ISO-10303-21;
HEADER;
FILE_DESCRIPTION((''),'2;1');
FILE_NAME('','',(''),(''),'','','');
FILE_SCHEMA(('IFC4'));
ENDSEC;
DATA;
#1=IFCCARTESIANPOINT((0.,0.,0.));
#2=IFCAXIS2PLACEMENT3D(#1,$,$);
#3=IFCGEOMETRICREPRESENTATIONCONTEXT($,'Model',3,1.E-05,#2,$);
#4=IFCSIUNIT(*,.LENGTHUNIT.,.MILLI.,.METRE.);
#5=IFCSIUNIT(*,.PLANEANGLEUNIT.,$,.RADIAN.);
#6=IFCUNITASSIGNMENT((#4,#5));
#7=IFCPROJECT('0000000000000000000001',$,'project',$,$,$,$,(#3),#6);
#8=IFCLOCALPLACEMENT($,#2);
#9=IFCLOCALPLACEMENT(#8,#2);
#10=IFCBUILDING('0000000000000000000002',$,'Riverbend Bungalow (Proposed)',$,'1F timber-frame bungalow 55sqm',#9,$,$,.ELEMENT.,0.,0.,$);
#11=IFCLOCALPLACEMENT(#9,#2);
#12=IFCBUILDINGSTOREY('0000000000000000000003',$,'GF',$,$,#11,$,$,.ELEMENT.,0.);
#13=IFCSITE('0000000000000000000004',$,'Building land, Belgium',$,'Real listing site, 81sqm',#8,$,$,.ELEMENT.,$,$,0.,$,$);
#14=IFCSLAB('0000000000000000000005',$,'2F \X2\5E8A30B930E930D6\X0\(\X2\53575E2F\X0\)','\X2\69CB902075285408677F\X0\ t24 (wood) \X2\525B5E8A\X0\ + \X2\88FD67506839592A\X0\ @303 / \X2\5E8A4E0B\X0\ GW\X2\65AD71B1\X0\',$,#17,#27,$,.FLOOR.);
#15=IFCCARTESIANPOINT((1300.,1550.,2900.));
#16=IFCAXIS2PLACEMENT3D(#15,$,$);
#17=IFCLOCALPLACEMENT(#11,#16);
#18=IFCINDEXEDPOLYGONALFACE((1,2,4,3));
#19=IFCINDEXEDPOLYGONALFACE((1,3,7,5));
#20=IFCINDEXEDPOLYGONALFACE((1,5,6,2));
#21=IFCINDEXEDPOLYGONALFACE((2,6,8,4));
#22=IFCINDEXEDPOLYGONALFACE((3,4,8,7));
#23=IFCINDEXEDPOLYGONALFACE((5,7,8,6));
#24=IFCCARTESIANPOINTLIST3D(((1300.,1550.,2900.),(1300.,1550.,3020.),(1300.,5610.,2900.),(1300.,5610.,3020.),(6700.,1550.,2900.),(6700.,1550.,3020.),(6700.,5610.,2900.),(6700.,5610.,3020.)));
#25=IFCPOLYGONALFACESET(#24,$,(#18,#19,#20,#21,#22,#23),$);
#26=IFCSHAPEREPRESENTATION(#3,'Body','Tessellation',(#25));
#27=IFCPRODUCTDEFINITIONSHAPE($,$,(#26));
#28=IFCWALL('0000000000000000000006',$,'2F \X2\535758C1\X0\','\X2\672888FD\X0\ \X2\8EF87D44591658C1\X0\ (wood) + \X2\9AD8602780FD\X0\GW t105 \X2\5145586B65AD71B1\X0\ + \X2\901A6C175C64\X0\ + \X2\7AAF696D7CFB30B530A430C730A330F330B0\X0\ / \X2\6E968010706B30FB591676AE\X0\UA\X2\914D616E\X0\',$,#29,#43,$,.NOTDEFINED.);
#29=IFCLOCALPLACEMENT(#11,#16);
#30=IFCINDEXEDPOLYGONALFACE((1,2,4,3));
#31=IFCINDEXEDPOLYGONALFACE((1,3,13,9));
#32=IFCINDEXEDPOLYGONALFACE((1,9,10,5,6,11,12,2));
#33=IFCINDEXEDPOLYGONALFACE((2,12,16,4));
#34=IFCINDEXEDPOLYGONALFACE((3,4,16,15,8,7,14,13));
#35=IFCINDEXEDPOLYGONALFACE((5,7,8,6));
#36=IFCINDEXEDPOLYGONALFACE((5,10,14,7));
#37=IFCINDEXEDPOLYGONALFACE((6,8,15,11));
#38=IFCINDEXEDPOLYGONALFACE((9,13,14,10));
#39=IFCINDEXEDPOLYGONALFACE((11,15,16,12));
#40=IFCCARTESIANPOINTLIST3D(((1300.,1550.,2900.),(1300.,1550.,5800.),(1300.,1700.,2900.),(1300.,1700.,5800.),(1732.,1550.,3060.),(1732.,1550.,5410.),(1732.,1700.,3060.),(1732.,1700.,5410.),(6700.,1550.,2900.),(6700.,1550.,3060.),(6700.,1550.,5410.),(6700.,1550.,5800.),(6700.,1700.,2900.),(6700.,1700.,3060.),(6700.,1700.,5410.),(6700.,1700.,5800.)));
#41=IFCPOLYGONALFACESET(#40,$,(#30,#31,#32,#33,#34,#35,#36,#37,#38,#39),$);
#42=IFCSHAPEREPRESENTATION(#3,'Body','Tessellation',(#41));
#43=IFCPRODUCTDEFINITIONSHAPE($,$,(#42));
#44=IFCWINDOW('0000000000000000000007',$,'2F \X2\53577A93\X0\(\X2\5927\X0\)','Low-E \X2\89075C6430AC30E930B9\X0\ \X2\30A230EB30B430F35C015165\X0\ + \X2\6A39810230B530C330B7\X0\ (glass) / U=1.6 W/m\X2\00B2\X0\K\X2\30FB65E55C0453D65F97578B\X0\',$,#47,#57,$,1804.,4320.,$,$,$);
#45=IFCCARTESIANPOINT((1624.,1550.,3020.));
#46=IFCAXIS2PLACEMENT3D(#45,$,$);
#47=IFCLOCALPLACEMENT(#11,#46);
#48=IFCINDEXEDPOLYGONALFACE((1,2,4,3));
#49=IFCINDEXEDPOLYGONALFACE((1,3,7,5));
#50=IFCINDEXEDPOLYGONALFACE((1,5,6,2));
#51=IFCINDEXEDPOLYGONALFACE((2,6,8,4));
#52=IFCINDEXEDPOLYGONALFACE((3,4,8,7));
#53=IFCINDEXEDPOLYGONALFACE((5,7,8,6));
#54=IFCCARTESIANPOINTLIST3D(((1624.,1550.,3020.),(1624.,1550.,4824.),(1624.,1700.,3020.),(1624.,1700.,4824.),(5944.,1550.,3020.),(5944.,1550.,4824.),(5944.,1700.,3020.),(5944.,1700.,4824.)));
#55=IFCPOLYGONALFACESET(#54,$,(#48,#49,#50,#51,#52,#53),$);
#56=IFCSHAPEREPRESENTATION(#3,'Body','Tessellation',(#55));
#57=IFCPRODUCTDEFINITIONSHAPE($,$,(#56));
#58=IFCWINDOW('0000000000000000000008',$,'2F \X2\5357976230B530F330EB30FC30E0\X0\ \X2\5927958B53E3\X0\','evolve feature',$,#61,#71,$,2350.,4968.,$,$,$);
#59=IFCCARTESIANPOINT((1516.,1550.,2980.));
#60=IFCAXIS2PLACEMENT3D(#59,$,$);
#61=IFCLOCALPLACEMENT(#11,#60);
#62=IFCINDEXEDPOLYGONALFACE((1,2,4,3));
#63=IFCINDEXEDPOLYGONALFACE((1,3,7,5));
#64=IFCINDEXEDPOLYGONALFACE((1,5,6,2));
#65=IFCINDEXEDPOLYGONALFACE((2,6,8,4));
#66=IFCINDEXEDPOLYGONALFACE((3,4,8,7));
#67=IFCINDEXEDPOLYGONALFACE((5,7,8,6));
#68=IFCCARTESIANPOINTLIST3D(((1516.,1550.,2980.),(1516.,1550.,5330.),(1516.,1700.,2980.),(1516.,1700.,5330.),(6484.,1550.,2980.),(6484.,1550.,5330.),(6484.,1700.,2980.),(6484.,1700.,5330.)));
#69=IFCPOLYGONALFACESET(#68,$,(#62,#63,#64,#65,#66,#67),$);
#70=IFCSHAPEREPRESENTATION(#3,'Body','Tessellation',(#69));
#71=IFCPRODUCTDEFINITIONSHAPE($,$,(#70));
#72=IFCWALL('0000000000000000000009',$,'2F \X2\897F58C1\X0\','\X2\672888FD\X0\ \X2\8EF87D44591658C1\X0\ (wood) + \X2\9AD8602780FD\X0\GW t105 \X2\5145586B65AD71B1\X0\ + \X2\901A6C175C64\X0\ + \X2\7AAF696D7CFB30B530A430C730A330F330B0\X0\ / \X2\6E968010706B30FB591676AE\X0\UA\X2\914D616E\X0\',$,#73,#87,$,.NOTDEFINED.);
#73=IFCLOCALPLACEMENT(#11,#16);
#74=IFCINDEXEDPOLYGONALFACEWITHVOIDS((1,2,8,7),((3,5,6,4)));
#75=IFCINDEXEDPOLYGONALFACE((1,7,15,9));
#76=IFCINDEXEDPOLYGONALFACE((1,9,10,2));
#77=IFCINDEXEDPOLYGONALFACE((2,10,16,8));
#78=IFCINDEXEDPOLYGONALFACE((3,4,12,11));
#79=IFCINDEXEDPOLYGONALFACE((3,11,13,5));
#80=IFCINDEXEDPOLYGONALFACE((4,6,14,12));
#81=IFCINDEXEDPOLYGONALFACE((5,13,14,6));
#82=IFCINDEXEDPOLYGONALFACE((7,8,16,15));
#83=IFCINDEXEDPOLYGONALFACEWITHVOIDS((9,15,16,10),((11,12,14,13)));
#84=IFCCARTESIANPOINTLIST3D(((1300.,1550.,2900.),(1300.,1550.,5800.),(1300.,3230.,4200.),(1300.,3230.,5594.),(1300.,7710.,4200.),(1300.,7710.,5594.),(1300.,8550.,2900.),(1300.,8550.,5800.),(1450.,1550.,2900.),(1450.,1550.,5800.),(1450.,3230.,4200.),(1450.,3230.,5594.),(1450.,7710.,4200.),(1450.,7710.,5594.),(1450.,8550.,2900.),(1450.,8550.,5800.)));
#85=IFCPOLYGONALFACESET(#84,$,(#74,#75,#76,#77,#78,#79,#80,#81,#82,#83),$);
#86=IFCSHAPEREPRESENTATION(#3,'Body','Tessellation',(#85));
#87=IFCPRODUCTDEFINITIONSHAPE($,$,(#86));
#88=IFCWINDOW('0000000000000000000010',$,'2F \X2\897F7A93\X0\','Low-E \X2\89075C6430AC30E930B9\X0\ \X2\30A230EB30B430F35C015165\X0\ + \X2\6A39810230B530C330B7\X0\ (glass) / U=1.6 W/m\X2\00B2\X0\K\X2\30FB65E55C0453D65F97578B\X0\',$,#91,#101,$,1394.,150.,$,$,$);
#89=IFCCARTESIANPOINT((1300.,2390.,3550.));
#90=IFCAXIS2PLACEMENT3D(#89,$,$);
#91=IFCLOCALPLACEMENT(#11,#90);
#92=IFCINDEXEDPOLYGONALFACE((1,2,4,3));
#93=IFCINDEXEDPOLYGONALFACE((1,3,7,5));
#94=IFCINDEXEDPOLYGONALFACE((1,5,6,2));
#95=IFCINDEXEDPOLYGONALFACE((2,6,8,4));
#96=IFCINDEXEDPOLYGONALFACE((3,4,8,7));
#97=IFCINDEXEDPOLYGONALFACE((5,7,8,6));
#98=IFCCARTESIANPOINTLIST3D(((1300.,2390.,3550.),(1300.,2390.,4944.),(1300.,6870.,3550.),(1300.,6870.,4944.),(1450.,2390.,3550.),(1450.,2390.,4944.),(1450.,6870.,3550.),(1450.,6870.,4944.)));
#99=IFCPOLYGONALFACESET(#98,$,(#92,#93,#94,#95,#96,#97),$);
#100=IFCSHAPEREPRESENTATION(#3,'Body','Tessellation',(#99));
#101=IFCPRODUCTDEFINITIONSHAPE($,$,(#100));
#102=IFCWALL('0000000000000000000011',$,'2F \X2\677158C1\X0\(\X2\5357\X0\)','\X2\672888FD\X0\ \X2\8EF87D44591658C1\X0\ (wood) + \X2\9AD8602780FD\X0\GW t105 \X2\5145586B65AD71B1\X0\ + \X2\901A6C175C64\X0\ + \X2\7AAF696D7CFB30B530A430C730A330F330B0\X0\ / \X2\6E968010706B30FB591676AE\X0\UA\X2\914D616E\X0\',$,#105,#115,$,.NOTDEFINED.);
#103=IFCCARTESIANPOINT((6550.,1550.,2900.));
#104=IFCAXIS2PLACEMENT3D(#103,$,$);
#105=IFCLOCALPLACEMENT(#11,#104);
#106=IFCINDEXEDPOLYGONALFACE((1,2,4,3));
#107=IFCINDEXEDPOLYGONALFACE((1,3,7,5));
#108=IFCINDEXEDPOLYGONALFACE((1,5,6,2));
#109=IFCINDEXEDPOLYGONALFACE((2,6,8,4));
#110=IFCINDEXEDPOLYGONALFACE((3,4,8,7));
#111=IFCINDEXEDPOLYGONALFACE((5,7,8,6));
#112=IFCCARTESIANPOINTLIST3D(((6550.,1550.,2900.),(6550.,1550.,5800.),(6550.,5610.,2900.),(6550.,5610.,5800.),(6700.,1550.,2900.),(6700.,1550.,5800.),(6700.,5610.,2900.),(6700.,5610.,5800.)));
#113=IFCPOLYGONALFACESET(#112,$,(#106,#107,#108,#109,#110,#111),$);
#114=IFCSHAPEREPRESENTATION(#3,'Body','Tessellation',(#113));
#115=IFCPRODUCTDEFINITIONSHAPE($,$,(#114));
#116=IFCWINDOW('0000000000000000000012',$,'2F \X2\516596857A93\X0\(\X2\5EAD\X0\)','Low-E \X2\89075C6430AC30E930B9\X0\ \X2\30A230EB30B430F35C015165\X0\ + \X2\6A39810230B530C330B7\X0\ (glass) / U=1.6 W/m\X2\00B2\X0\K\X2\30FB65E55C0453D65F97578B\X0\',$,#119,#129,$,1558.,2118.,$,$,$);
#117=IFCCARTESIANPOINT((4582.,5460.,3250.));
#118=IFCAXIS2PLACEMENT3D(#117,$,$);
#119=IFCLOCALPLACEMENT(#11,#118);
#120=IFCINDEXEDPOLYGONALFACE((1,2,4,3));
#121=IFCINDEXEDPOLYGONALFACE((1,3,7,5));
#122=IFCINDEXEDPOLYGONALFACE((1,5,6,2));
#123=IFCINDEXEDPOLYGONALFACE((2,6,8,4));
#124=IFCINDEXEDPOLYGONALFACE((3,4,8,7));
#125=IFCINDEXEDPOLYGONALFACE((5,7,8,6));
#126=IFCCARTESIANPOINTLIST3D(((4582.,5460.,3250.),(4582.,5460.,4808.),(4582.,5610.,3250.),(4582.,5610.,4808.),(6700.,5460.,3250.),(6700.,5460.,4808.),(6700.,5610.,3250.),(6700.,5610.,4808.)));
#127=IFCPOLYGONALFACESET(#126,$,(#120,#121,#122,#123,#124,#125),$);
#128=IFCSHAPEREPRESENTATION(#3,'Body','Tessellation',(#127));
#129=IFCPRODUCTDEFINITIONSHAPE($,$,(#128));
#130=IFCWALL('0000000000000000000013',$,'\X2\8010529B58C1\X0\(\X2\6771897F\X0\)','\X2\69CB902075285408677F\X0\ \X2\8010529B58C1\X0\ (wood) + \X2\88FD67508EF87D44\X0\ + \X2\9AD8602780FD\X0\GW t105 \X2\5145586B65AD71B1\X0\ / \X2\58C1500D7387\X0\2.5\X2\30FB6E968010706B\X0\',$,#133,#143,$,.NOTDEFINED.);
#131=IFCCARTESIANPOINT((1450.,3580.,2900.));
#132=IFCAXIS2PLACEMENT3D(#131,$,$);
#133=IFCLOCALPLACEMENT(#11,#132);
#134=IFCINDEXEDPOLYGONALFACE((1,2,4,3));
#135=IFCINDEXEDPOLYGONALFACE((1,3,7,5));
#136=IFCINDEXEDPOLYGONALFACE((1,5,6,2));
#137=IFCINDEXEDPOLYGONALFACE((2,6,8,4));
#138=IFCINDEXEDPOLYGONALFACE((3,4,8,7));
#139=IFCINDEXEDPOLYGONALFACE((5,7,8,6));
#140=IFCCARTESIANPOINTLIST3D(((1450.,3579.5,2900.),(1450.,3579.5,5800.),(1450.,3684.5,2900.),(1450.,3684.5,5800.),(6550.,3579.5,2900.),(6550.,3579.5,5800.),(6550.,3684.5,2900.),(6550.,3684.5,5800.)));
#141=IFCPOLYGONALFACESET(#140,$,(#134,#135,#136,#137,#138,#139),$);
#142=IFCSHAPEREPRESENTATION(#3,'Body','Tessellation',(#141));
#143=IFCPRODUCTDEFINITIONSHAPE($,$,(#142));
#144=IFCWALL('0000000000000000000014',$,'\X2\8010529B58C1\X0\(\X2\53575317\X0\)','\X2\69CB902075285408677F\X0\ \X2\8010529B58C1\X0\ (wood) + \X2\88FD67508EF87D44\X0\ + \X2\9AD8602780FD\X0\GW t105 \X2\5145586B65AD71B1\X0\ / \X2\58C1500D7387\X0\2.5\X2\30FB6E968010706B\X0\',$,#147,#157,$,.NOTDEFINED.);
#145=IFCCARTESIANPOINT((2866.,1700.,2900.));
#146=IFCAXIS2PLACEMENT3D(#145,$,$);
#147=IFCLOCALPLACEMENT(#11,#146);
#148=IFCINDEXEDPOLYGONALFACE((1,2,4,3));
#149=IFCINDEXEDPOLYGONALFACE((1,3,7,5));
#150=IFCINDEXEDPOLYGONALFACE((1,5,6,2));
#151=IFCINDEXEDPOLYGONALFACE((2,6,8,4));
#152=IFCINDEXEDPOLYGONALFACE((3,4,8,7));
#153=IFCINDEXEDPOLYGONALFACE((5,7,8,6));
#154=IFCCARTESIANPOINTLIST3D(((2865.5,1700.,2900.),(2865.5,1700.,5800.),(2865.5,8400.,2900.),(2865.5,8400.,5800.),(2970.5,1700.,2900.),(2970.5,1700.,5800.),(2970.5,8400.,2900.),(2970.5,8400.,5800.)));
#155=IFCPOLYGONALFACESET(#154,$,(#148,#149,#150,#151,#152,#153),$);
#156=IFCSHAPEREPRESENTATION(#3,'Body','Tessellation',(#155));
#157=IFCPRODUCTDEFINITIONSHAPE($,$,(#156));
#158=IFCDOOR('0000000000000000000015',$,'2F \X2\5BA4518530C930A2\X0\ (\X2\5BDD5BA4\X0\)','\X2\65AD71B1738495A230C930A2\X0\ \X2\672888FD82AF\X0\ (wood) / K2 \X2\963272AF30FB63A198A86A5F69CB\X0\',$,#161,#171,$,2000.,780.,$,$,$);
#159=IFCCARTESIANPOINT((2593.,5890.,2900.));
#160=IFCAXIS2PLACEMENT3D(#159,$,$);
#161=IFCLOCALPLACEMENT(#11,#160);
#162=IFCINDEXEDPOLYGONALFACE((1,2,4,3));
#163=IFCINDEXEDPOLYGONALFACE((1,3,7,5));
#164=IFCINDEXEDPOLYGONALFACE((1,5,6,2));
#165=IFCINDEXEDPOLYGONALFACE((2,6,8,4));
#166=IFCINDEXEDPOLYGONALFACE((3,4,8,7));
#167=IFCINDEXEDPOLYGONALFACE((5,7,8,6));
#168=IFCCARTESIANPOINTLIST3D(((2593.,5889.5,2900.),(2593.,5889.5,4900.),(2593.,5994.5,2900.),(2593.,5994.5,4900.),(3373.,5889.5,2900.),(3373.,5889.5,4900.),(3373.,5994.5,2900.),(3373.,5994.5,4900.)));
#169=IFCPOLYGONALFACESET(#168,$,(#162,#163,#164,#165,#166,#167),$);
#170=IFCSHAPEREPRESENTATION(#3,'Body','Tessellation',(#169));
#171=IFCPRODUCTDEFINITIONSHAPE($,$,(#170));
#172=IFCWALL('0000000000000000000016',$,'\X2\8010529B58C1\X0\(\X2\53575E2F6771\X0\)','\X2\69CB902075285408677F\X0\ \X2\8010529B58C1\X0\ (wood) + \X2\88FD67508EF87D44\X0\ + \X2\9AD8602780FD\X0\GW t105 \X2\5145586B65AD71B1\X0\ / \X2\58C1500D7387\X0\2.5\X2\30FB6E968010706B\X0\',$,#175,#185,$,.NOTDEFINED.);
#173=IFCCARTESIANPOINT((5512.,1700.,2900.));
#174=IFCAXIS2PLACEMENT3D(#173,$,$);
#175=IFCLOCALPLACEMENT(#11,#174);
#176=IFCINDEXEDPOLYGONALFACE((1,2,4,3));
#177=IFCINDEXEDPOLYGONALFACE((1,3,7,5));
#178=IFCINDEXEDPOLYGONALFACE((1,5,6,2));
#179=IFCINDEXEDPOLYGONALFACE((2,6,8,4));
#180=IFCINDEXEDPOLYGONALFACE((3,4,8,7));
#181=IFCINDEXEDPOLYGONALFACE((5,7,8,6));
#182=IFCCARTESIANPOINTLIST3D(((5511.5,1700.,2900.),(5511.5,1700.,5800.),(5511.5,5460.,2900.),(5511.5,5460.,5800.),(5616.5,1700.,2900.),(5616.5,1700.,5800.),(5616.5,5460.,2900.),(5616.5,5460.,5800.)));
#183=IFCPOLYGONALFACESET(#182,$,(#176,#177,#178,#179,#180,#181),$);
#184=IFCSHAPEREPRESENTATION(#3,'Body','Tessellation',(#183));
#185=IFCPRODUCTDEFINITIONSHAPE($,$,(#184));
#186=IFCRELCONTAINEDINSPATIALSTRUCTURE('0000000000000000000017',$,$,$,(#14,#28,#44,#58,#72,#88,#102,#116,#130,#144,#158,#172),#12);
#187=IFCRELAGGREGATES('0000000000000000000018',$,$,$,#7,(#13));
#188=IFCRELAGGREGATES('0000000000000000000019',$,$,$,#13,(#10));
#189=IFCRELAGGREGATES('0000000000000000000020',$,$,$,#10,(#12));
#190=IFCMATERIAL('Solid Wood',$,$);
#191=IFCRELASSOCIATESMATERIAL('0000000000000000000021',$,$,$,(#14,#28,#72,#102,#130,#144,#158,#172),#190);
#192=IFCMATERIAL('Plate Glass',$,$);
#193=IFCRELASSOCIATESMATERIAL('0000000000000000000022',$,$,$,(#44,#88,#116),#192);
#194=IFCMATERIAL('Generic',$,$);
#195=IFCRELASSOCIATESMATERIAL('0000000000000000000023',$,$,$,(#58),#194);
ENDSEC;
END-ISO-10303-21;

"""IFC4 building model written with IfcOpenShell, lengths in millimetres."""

from ifc_helpers import new_model, si_unit, frame, frame_2d, origin, place, context, project, spatial, rectangle, extrude, material, element, fill, save


model = new_model("IFC4")

# Units and contexts
model_context = context("Model", 3, precision=1e-05, world=origin())
ifc_project = project(units=[si_unit("LENGTHUNIT", "METRE", prefix="MILLI"), si_unit("PLANEANGLEUNIT", "RADIAN")], contexts=[model_context])

# Site, building, storey
site_placement = place(None, origin())
site = spatial("IfcSite", under=ifc_project, at=site_placement, Name="Building land, Belgium", ObjectType="Real listing site, 81sqm", CompositionType="ELEMENT", RefElevation=0.0)
building_placement = place(site_placement, origin())
building = spatial("IfcBuilding", under=site, at=building_placement, Name="Riverbend Bungalow (Proposed)", ObjectType="1F timber-frame bungalow 55sqm", CompositionType="ELEMENT", ElevationOfRefHeight=0.0, ElevationOfTerrain=0.0)
storey_placement = place(building_placement, origin())
storey = spatial("IfcBuildingStorey", under=building, at=storey_placement, Name="GF", CompositionType="ELEMENT", Elevation=0.0)

# Slab
ifc_material_1 = material(Name="Solid Wood")
slab_placement = place(storey_placement, frame((1300.0, 1550.0, 2900.0)))
element("IfcSlab", 1, at=slab_placement, inside=storey, material=ifc_material_1, Name="2F 床スラブ(南帯)", Description="構造用合板 t24 (wood) 剛床 + 製材根太 @303 / 床下 GW断熱", PredefinedType="FLOOR", context=model_context, shape_type="SweptSolid", body=[
    extrude(rectangle(XDim=5400.0, YDim=4060.0, at=frame_2d((2700.0, 2030.0))), frame((1300.0, 1550.0, 2900.0)), (0.0, 0.0, 1.0), 120.0),
])

# Wall, openings, windows
wall_1_placement = place(storey_placement, frame((1300.0, 1550.0, 2900.0)))
wall_1 = element("IfcWall", 2, at=wall_1_placement, inside=storey, material=ifc_material_1, Name="2F 南壁", Description="木製 軸組外壁 (wood) + 高性能GW t105 充填断熱 + 通気層 + 窯業系サイディング / 準耐火・外皮UA配慮", PredefinedType="NOTDEFINED", context=model_context, shape_type="SweptSolid", body=[
    extrude(rectangle(XDim=5400.0, YDim=150.0, at=frame_2d((2700.0, 75.0))), frame((1300.0, 1550.0, 2900.0)), (0.0, 0.0, 1.0), 2900.0),
])
opening_1_placement = place(storey_placement, frame((1624.0, 1550.0, 3020.0)))
opening_1 = element("IfcOpeningElement", 3, at=opening_1_placement, cuts=wall_1, PredefinedType="NOTDEFINED", context=model_context, shape_type="SweptSolid", body=[
    extrude(rectangle(XDim=4320.0, YDim=150.0, at=frame_2d((2160.0, 75.0))), frame((1624.0, 1550.0, 3020.0)), (0.0, 0.0, 1.0), 1804.0),
])
opening_2_placement = place(storey_placement, frame((1516.0, 1550.0, 2980.0)))
opening_2 = element("IfcOpeningElement", 4, at=opening_2_placement, cuts=wall_1, PredefinedType="NOTDEFINED", context=model_context, shape_type="SweptSolid", body=[
    extrude(rectangle(XDim=4968.0, YDim=150.0, at=frame_2d((2484.0, 75.0))), frame((1516.0, 1550.0, 2980.0)), (0.0, 0.0, 1.0), 2350.0),
])
ifc_material_2 = material(Name="Plate Glass")
window_1_placement = place(storey_placement, frame((1624.0, 1550.0, 3020.0)))
window_1 = element("IfcWindow", 5, at=window_1_placement, inside=storey, material=ifc_material_2, Name="2F 南窓(大)", Description="Low-E 複層ガラス アルゴン封入 + 樹脂サッシ (glass) / U=1.6 W/m²K・日射取得型", OverallHeight=1804.0, OverallWidth=4320.0, context=model_context, shape_type="SweptSolid", body=[
    extrude(rectangle(XDim=4320.0, YDim=150.0, at=frame_2d((2160.0, 75.0))), frame((1624.0, 1550.0, 3020.0)), (0.0, 0.0, 1.0), 1804.0),
])
fill(opening_1, window_1)
ifc_material_3 = material(Name="Generic")
window_2_placement = place(storey_placement, frame((1516.0, 1550.0, 2980.0)))
window_2 = element("IfcWindow", 6, at=window_2_placement, inside=storey, material=ifc_material_3, Name="2F 南面サンルーム 大開口", Description="evolve feature", OverallHeight=2350.0, OverallWidth=4968.0, context=model_context, shape_type="SweptSolid", body=[
    extrude(rectangle(XDim=4968.0, YDim=150.0, at=frame_2d((2484.0, 75.0))), frame((1516.0, 1550.0, 2980.0)), (0.0, 0.0, 1.0), 2350.0),
])
fill(opening_2, window_2)

# Walls, openings, windows
wall_2_placement = place(storey_placement, frame((1300.0, 1550.0, 2900.0)))
wall_2 = element("IfcWall", 7, at=wall_2_placement, inside=storey, material=ifc_material_1, Name="2F 西壁", Description="木製 軸組外壁 (wood) + 高性能GW t105 充填断熱 + 通気層 + 窯業系サイディング / 準耐火・外皮UA配慮", PredefinedType="NOTDEFINED", context=model_context, shape_type="SweptSolid", body=[
    extrude(rectangle(XDim=150.0, YDim=7000.0, at=frame_2d((75.0, 3500.0))), frame((1300.0, 1550.0, 2900.0)), (0.0, 0.0, 1.0), 2900.0),
])
opening_3_placement = place(storey_placement, frame((1300.0, 2390.0, 3550.0)))
opening_3 = element("IfcOpeningElement", 8, at=opening_3_placement, cuts=wall_2, PredefinedType="NOTDEFINED", context=model_context, shape_type="SweptSolid", body=[
    extrude(rectangle(XDim=150.0, YDim=4480.0, at=frame_2d((75.0, 2240.0))), frame((1300.0, 2390.0, 3550.0)), (0.0, 0.0, 1.0), 1394.0),
])
window_3_placement = place(storey_placement, frame((1300.0, 2390.0, 3550.0)))
window_3 = element("IfcWindow", 9, at=window_3_placement, inside=storey, material=ifc_material_2, Name="2F 西窓", Description="Low-E 複層ガラス アルゴン封入 + 樹脂サッシ (glass) / U=1.6 W/m²K・日射取得型", OverallHeight=1394.0, OverallWidth=150.0, context=model_context, shape_type="SweptSolid", body=[
    extrude(rectangle(XDim=150.0, YDim=4480.0, at=frame_2d((75.0, 2240.0))), frame((1300.0, 2390.0, 3550.0)), (0.0, 0.0, 1.0), 1394.0),
])
fill(opening_3, window_3)
wall_3_placement = place(storey_placement, frame((6550.0, 1550.0, 2900.0)))
wall_3 = element("IfcWall", 10, at=wall_3_placement, inside=storey, material=ifc_material_1, Name="2F 東壁(南)", Description="木製 軸組外壁 (wood) + 高性能GW t105 充填断熱 + 通気層 + 窯業系サイディング / 準耐火・外皮UA配慮", PredefinedType="NOTDEFINED", context=model_context, shape_type="SweptSolid", body=[
    extrude(rectangle(XDim=150.0, YDim=4060.0, at=frame_2d((75.0, 2030.0))), frame((6550.0, 1550.0, 2900.0)), (0.0, 0.0, 1.0), 2900.0),
])
opening_4_placement = place(storey_placement, frame((4582.0, 5460.0, 3250.0)))
opening_4 = element("IfcOpeningElement", 11, at=opening_4_placement, cuts=wall_3, PredefinedType="NOTDEFINED", context=model_context, shape_type="SweptSolid", body=[
    extrude(rectangle(XDim=2118.0, YDim=150.0, at=frame_2d((1059.0, 75.0))), frame((4582.0, 5460.0, 3250.0)), (0.0, 0.0, 1.0), 1558.0),
])
window_4_placement = place(storey_placement, frame((4582.0, 5460.0, 3250.0)))
window_4 = element("IfcWindow", 12, at=window_4_placement, inside=storey, material=ifc_material_2, Name="2F 入隅窓(庭)", Description="Low-E 複層ガラス アルゴン封入 + 樹脂サッシ (glass) / U=1.6 W/m²K・日射取得型", OverallHeight=1558.0, OverallWidth=2118.0, context=model_context, shape_type="SweptSolid", body=[
    extrude(rectangle(XDim=2118.0, YDim=150.0, at=frame_2d((1059.0, 75.0))), frame((4582.0, 5460.0, 3250.0)), (0.0, 0.0, 1.0), 1558.0),
])
fill(opening_4, window_4)

# Wall
wall_4_placement = place(storey_placement, frame((1450.0, 3580.0, 2900.0)))
element("IfcWall", 13, at=wall_4_placement, inside=storey, material=ifc_material_1, Name="耐力壁(東西)", Description="構造用合板 耐力壁 (wood) + 製材軸組 + 高性能GW t105 充填断熱 / 壁倍率2.5・準耐火", PredefinedType="NOTDEFINED", context=model_context, shape_type="SweptSolid", body=[
    extrude(rectangle(XDim=5100.0, YDim=105.0, at=frame_2d((2550.0, 52.0))), frame((1450.0, 3580.0, 2900.0)), (0.0, 0.0, 1.0), 2900.0),
])

# Wall, opening, door
wall_5_placement = place(storey_placement, frame((2866.0, 1700.0, 2900.0)))
wall_5 = element("IfcWall", 14, at=wall_5_placement, inside=storey, material=ifc_material_1, Name="耐力壁(南北)", Description="構造用合板 耐力壁 (wood) + 製材軸組 + 高性能GW t105 充填断熱 / 壁倍率2.5・準耐火", PredefinedType="NOTDEFINED", context=model_context, shape_type="SweptSolid", body=[
    extrude(rectangle(XDim=105.0, YDim=6700.0, at=frame_2d((52.0, 3350.0))), frame((2866.0, 1700.0, 2900.0)), (0.0, 0.0, 1.0), 2900.0),
])
opening_5_placement = place(storey_placement, frame((2593.0, 5890.0, 2900.0)))
opening_5 = element("IfcOpeningElement", 15, at=opening_5_placement, cuts=wall_5, PredefinedType="NOTDEFINED", context=model_context, shape_type="SweptSolid", body=[
    extrude(rectangle(XDim=780.0, YDim=105.0, at=frame_2d((390.0, 52.0))), frame((2593.0, 5890.0, 2900.0)), (0.0, 0.0, 1.0), 2000.0),
])
door_placement = place(storey_placement, frame((2593.0, 5890.0, 2900.0)))
door = element("IfcDoor", 16, at=door_placement, inside=storey, material=ifc_material_1, Name="2F 室内ドア (寝室)", Description="断熱玄関ドア 木製芯 (wood) / K2 防犯・採風機構", OverallHeight=2000.0, OverallWidth=780.0, context=model_context, shape_type="SweptSolid", body=[
    extrude(rectangle(XDim=780.0, YDim=105.0, at=frame_2d((390.0, 52.0))), frame((2593.0, 5890.0, 2900.0)), (0.0, 0.0, 1.0), 2000.0),
])
fill(opening_5, door)

# Wall
wall_6_placement = place(storey_placement, frame((5512.0, 1700.0, 2900.0)))
element("IfcWall", 17, at=wall_6_placement, inside=storey, material=ifc_material_1, Name="耐力壁(南帯東)", Description="構造用合板 耐力壁 (wood) + 製材軸組 + 高性能GW t105 充填断熱 / 壁倍率2.5・準耐火", PredefinedType="NOTDEFINED", context=model_context, shape_type="SweptSolid", body=[
    extrude(rectangle(XDim=105.0, YDim=3760.0, at=frame_2d((52.0, 1880.0))), frame((5512.0, 1700.0, 2900.0)), (0.0, 0.0, 1.0), 2900.0),
])

save(model, "model.ifc")
